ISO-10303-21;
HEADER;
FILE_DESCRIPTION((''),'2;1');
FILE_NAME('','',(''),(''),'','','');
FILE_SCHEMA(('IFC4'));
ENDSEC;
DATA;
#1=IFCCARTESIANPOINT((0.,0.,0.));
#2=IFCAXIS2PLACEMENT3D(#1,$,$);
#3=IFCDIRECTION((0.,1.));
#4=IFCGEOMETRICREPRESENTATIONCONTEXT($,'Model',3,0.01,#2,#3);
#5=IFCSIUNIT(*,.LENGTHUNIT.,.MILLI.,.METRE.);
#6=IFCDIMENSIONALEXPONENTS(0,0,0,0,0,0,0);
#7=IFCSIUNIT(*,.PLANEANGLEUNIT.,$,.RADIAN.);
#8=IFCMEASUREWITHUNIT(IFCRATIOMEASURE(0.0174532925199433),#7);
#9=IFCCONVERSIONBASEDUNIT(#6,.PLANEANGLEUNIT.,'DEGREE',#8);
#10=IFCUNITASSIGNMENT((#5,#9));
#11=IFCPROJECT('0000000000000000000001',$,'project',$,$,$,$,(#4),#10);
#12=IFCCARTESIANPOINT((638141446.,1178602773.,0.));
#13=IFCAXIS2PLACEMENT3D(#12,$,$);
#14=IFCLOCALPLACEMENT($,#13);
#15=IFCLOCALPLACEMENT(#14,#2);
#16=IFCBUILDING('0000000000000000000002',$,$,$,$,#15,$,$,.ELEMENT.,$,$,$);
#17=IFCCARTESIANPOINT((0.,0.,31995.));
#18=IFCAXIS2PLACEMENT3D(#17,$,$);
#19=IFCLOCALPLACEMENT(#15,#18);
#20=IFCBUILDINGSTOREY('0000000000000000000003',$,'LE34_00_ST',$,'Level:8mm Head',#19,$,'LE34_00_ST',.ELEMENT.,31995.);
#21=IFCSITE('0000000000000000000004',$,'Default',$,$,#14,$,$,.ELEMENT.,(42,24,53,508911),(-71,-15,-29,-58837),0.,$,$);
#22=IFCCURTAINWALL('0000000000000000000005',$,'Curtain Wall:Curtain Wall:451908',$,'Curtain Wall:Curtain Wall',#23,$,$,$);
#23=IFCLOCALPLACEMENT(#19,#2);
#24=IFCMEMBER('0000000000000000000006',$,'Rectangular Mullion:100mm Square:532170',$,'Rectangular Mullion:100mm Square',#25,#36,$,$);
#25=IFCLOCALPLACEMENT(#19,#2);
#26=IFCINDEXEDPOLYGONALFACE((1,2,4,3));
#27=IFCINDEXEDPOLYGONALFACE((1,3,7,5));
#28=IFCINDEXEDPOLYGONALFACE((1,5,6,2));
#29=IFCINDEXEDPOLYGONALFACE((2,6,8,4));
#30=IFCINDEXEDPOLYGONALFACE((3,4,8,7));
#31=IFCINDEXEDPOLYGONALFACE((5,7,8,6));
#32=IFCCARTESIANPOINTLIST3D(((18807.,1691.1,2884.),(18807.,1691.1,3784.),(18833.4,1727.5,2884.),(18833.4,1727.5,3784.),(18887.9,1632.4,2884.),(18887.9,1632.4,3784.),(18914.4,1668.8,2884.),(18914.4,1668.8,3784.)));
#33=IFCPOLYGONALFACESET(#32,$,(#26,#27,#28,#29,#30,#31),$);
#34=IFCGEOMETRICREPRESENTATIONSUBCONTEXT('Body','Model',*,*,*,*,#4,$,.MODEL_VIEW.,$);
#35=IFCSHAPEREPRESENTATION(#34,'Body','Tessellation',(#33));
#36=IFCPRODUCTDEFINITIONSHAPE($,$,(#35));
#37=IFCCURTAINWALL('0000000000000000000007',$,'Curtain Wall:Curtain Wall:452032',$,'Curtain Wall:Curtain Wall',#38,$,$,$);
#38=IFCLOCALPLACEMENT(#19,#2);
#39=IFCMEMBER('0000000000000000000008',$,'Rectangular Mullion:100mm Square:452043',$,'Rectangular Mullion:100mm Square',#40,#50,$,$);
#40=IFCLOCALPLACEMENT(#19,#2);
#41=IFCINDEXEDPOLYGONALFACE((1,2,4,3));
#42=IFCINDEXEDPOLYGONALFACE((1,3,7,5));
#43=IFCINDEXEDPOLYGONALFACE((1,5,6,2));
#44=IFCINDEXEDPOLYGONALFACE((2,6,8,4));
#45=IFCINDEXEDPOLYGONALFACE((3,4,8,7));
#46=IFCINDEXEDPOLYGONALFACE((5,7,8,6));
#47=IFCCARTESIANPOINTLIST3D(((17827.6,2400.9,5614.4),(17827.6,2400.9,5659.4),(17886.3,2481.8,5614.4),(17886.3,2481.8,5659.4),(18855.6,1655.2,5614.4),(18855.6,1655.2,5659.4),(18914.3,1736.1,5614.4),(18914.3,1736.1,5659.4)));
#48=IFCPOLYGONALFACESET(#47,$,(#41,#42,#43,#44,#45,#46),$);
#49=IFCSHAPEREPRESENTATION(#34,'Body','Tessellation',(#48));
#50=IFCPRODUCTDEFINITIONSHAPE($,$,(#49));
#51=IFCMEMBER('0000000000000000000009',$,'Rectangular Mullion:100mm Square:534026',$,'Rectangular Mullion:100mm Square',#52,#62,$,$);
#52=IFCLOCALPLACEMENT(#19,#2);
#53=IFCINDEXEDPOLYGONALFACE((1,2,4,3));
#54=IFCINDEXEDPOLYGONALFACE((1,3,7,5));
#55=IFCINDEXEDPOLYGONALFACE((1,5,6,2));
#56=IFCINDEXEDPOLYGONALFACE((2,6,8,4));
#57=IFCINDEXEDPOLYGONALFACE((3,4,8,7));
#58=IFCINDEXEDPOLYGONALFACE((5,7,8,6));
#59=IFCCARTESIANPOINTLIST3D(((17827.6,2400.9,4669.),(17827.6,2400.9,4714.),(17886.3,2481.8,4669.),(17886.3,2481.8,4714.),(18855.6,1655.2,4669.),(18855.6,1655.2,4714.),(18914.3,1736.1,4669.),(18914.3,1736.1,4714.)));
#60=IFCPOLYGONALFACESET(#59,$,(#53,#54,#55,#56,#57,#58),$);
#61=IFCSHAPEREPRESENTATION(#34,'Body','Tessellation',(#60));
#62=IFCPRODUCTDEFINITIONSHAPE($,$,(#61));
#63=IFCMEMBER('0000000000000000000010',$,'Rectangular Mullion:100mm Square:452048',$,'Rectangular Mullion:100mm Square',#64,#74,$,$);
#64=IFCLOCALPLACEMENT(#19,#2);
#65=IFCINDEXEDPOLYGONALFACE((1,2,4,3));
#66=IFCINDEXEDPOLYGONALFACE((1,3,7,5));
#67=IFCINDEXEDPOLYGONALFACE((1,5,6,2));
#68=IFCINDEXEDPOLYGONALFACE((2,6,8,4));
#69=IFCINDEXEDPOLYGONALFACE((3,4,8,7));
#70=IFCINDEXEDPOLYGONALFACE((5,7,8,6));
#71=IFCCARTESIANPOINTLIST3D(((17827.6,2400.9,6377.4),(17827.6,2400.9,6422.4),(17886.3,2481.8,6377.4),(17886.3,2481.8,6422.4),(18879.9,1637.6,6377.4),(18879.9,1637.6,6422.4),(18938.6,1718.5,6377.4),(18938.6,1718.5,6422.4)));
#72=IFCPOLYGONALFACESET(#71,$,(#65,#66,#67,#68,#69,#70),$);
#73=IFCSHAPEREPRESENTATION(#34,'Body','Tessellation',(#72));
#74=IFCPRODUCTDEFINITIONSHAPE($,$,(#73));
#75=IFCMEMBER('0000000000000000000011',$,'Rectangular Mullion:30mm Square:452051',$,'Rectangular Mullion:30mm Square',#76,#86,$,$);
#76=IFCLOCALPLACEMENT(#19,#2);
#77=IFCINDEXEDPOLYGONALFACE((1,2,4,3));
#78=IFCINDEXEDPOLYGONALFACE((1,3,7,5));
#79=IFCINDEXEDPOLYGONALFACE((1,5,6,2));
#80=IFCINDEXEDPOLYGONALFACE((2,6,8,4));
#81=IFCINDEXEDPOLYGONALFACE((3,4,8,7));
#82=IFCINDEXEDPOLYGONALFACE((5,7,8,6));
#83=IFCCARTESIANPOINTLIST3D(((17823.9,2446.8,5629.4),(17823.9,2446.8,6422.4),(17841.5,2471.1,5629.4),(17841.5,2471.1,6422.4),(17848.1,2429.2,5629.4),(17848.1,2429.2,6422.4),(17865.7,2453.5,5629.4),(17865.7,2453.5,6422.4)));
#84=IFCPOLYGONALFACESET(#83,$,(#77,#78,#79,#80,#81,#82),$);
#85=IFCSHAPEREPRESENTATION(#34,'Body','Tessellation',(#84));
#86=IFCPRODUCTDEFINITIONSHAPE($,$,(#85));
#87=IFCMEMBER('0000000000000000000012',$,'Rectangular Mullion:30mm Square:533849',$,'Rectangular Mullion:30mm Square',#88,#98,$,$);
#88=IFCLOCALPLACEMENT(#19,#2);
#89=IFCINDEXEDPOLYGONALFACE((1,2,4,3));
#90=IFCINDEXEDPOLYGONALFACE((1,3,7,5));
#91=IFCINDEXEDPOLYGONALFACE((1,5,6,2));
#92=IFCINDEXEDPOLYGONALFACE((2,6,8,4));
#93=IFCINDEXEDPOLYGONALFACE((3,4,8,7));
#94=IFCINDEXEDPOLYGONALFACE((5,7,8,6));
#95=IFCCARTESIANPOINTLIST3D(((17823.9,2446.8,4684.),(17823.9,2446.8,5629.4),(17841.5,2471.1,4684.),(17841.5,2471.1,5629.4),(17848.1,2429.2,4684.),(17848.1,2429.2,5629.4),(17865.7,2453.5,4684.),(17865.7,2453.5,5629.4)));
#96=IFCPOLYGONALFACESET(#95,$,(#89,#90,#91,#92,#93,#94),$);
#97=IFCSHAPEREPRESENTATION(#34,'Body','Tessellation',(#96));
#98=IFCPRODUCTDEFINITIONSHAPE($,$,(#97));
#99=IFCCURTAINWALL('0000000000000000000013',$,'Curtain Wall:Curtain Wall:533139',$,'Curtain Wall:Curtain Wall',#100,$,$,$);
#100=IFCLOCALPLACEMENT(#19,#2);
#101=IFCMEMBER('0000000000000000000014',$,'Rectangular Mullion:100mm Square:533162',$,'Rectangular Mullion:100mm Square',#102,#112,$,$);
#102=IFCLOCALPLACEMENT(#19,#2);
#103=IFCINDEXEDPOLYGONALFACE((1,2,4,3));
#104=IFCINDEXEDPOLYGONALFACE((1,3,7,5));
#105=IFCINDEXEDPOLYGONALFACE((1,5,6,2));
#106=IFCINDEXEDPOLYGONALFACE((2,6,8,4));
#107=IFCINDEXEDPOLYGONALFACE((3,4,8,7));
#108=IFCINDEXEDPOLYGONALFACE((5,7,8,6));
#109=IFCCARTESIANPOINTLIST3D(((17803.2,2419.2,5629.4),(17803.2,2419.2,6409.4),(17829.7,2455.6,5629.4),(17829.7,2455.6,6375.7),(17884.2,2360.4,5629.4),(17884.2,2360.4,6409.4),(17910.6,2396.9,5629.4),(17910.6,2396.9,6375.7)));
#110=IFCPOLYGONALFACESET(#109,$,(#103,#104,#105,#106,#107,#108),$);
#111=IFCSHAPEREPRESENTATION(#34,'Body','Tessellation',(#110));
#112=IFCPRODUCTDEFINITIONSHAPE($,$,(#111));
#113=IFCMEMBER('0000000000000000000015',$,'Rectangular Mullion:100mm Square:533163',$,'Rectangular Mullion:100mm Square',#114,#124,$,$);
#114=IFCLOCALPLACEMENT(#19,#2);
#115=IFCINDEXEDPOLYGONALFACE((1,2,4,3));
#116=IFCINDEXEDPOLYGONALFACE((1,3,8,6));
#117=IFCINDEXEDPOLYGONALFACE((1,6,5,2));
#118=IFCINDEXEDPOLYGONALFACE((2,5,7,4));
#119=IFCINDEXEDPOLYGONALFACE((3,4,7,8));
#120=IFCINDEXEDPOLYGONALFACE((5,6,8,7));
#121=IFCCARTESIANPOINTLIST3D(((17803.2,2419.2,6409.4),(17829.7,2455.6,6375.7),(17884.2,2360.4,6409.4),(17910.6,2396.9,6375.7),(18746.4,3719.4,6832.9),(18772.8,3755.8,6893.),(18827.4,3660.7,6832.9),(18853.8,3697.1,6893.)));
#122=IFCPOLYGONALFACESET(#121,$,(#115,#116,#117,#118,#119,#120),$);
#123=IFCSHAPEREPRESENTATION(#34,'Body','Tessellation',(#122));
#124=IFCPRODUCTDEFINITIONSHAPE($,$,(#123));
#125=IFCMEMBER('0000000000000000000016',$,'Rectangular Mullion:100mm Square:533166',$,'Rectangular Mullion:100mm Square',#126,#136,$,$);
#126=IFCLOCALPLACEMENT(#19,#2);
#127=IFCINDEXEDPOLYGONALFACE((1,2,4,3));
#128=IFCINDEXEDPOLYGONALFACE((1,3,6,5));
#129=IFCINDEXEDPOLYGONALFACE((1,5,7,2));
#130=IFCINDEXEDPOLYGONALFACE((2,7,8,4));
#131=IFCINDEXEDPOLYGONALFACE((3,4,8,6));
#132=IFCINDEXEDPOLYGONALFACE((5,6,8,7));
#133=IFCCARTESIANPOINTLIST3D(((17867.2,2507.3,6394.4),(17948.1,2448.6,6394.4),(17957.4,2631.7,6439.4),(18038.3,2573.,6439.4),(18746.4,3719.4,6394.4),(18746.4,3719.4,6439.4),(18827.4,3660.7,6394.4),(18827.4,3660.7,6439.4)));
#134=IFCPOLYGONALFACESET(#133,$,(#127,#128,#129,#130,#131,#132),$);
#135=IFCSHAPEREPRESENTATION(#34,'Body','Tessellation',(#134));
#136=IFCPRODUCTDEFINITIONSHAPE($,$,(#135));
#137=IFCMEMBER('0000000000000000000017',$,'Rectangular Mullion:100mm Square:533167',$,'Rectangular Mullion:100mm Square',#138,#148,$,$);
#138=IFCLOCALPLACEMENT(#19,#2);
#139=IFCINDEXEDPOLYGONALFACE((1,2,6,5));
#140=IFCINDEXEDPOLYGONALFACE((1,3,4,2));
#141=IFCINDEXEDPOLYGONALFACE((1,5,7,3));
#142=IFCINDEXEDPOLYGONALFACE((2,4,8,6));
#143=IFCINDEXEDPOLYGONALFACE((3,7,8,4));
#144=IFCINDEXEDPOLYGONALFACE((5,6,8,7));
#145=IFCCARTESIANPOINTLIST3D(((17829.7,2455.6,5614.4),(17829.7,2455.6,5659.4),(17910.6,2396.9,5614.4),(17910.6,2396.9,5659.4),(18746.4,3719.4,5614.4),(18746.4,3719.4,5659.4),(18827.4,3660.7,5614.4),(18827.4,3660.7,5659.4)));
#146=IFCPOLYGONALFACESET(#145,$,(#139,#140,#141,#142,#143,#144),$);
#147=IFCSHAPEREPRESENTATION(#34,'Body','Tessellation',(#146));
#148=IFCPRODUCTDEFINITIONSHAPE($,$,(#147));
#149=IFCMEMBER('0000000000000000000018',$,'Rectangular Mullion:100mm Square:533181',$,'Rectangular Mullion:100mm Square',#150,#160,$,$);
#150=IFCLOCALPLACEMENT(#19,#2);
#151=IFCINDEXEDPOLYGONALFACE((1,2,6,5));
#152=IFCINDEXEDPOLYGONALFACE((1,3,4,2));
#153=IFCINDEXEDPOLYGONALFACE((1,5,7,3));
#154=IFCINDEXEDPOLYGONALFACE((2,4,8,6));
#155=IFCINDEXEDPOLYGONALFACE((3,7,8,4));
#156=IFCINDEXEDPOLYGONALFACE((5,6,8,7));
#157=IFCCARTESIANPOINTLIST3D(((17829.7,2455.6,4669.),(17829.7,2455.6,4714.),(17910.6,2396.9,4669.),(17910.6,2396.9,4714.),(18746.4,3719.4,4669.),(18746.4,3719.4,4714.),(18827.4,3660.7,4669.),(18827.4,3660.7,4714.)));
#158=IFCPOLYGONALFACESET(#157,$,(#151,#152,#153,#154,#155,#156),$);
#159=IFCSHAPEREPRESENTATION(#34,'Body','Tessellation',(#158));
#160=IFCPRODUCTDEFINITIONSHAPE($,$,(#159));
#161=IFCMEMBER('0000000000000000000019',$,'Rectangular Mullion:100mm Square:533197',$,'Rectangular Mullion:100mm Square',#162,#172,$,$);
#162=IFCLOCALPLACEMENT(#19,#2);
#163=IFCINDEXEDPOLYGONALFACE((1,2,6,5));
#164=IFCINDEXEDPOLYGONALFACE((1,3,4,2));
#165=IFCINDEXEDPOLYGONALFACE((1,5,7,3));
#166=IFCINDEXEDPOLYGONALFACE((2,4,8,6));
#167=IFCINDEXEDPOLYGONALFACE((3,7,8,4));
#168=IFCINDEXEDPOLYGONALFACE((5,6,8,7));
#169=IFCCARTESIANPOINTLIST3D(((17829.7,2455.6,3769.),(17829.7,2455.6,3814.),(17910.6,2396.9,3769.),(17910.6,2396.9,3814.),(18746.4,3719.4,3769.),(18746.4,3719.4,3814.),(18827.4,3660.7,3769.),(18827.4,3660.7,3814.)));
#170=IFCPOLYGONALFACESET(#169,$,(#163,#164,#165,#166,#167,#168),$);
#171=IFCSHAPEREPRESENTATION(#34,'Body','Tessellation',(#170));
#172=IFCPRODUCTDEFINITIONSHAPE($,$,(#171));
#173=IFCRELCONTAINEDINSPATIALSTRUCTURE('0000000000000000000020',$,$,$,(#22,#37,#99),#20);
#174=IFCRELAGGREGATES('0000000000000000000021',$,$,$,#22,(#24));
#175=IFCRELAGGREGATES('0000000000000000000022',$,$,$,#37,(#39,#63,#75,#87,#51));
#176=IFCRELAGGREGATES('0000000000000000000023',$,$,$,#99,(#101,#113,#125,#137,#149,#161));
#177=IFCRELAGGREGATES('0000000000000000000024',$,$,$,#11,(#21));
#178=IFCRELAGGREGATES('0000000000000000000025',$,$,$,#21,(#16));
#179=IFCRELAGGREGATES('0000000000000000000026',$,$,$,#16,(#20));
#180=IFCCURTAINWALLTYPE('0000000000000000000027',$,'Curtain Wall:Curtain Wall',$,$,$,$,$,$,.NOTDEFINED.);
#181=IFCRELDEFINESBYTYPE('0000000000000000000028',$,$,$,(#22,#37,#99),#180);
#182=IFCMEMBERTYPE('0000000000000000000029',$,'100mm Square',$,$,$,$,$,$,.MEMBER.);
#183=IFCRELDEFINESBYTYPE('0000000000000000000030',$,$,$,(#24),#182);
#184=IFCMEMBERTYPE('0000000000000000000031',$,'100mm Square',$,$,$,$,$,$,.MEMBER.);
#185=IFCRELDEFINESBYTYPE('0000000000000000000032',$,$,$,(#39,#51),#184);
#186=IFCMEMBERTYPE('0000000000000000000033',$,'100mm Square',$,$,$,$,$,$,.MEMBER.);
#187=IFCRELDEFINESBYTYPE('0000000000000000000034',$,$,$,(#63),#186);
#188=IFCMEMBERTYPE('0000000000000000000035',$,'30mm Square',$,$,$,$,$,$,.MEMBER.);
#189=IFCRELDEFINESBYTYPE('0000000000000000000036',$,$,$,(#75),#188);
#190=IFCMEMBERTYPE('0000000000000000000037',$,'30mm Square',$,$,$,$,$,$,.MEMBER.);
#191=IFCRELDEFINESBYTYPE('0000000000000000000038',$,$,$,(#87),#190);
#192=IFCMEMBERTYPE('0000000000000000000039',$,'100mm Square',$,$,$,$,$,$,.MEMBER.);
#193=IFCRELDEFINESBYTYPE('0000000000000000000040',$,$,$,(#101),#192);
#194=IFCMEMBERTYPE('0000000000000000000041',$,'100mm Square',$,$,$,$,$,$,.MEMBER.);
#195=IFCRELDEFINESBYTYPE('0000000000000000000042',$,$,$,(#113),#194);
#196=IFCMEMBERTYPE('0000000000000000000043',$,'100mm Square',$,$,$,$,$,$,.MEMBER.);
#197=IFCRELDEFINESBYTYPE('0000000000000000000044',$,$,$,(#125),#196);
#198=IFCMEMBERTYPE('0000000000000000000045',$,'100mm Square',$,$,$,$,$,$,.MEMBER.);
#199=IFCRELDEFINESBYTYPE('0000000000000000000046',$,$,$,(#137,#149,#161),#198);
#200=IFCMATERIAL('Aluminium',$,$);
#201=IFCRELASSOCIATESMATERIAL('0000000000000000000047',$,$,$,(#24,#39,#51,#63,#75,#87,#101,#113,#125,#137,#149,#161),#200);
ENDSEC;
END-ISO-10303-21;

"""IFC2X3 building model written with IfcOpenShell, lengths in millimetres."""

from ifc_helpers import new_model, entity, si_unit, converted_unit, direction, frame, frame_2d, origin, origin_2d_with_axis, place, context, subcontext, project, spatial, rectangle, extrude, clip, halfspace, source, transform, mapped, material, type_object, type_shapes, element, aggregate, save


model = new_model("IFC2X3")

# Units and contexts
model_context = context("Model", 3, precision=0.01, world=origin(), true_north=direction((0.0, 1.0)))
body_context = subcontext(model_context, "Body", "Model", "MODEL_VIEW")
ifc_project = project(units=[si_unit("LENGTHUNIT", "METRE", prefix="MILLI"), converted_unit("PLANEANGLEUNIT", "DEGREE", entity("IfcRatioMeasure", 0.0174532925199433), si_unit("PLANEANGLEUNIT", "RADIAN"), dimensions=[0, 0, 0, 0, 0, 0, 0])], contexts=[model_context])

# Site, building, storey
site_placement = place(None, frame((638141446.0, 1178602773.0, 0.0)))
site = spatial("IfcSite", under=ifc_project, at=site_placement, Name="Default", CompositionType="ELEMENT", RefLatitude=(42, 24, 53, 508911), RefLongitude=(-71, -15, -29, -58837), RefElevation=0.0)
building_placement = place(site_placement, origin())
building = spatial("IfcBuilding", under=site, at=building_placement, CompositionType="ELEMENT")
storey_placement = place(building_placement, frame((0.0, 0.0, 31995.0)))
storey = spatial("IfcBuildingStorey", under=building, at=storey_placement, Name="LE34_00_ST", ObjectType="Level:8mm Head", LongName="LE34_00_ST", CompositionType="ELEMENT", Elevation=31995.0)

# Curtain wall, member
curtain_wall_type = type_object("IfcCurtainWallType", Name="Curtain Wall:Curtain Wall", PredefinedType="NOTDEFINED")
curtain_wall_1_placement = place(storey_placement, frame((0.0, 0.0, -31995.0)))
curtain_wall_1 = element("IfcCurtainWall", 1, at=curtain_wall_1_placement, inside=storey, type_object=curtain_wall_type, Name="Curtain Wall:Curtain Wall:451908", ObjectType="Curtain Wall:Curtain Wall")
ifc_material_1 = material(Name="Aluminium")
member_type_1 = type_object("IfcMemberType", Name="100mm Square", PredefinedType="MEMBER")
shared_shape_1 = source(origin(), body_context, "Body", "SweptSolid", [
    extrude(rectangle(XDim=100.0, YDim=45.0, at=origin_2d_with_axis()), frame((-22.5, 0.0, -900.0), z_axis=(0.0, 0.0, 1.0), x_axis=(0.0, -1.0, 0.0)), (0.0, 0.0, 1.0), 900.0),
])
type_shapes(member_type_1, [shared_shape_1])
member_1_placement = place(storey_placement, frame((18847.5, 1661.7, 3784.0), z_axis=(0.0, 0.0, 1.0), x_axis=(-0.587164, -0.809468, 0.0)))
member_1 = element("IfcMember", 2, at=member_1_placement, type_object=member_type_1, material=ifc_material_1, Name="Rectangular Mullion:100mm Square:532170", ObjectType="Rectangular Mullion:100mm Square", context=body_context, shape_type="MappedRepresentation", body=[
    mapped(shared_shape_1, transform((0.0, 0.0, 0.0), scale=1.0)),
])
aggregate(curtain_wall_1, [member_1])

# Curtain walls, members
curtain_wall_2_placement = place(storey_placement, frame((0.0, 0.0, -31995.0)))
curtain_wall_2 = element("IfcCurtainWall", 3, at=curtain_wall_2_placement, inside=storey, type_object=curtain_wall_type, Name="Curtain Wall:Curtain Wall:452032", ObjectType="Curtain Wall:Curtain Wall")
member_type_2 = type_object("IfcMemberType", Name="100mm Square", PredefinedType="MEMBER")
shared_shape_2 = source(origin(), body_context, "Body", "SweptSolid", [
    extrude(rectangle(XDim=100.0, YDim=45.0, at=origin_2d_with_axis()), frame((7.5, 0.0, -1270.0), z_axis=(0.0, 0.0, 1.0), x_axis=(0.0, -1.0, 0.0)), (0.0, 0.0, 1.0), 1270.0),
])
type_shapes(member_type_2, [shared_shape_2])
member_2_placement = place(storey_placement, frame((17856.9, 2441.4, 5629.4), z_axis=(-0.809468, 0.587164, 0.0), x_axis=(0.0, 0.0, 1.0)))
member_2 = element("IfcMember", 4, at=member_2_placement, type_object=member_type_2, material=ifc_material_1, Name="Rectangular Mullion:100mm Square:452043", ObjectType="Rectangular Mullion:100mm Square", context=body_context, shape_type="MappedRepresentation", body=[
    mapped(shared_shape_2, transform((0.0, 0.0, 0.0), scale=1.0)),
])
member_3_placement = place(storey_placement, frame((17856.9, 2441.4, 4684.0), z_axis=(-0.809468, 0.587164, 0.0), x_axis=(0.0, 0.0, 1.0)))
member_3 = element("IfcMember", 5, at=member_3_placement, type_object=member_type_2, material=ifc_material_1, Name="Rectangular Mullion:100mm Square:534026", ObjectType="Rectangular Mullion:100mm Square", context=body_context, shape_type="MappedRepresentation", body=[
    mapped(shared_shape_2, transform((0.0, 0.0, 0.0), scale=1.0)),
])
member_type_3 = type_object("IfcMemberType", Name="100mm Square", PredefinedType="MEMBER")
shared_shape_3 = source(origin(), body_context, "Body", "SweptSolid", [
    extrude(rectangle(XDim=100.0, YDim=45.0, at=origin_2d_with_axis()), frame((-22.5, 0.0, -1300.0), z_axis=(0.0, 0.0, 1.0), x_axis=(0.0, -1.0, 0.0)), (0.0, 0.0, 1.0), 1300.0),
])
type_shapes(member_type_3, [shared_shape_3])
member_4_placement = place(storey_placement, frame((17856.9, 2441.4, 6422.4), z_axis=(-0.809468, 0.587164, 0.0), x_axis=(0.0, 0.0, 1.0)))
member_4 = element("IfcMember", 6, at=member_4_placement, type_object=member_type_3, material=ifc_material_1, Name="Rectangular Mullion:100mm Square:452048", ObjectType="Rectangular Mullion:100mm Square", context=body_context, shape_type="MappedRepresentation", body=[
    mapped(shared_shape_3, transform((0.0, 0.0, 0.0), scale=1.0)),
])
member_type_4 = type_object("IfcMemberType", Name="30mm Square", PredefinedType="MEMBER")
shared_shape_4 = source(origin(), body_context, "Body", "SweptSolid", [
    extrude(rectangle(XDim=30.0, YDim=30.0, at=origin_2d_with_axis()), frame((-15.0, 0.0, -793.0), z_axis=(0.0, 0.0, 1.0), x_axis=(0.0, -1.0, 0.0)), (0.0, 0.0, 1.0), 793.0),
])
type_shapes(member_type_4, [shared_shape_4])
member_5_placement = place(storey_placement, frame((17832.7, 2459.0, 5629.4), z_axis=(0.0, 0.0, -1.0), x_axis=(-0.809468, 0.587164, 0.0)))
member_5 = element("IfcMember", 7, at=member_5_placement, type_object=member_type_4, material=ifc_material_1, Name="Rectangular Mullion:30mm Square:452051", ObjectType="Rectangular Mullion:30mm Square", context=body_context, shape_type="MappedRepresentation", body=[
    mapped(shared_shape_4, transform((0.0, 0.0, 0.0), scale=1.0)),
])
member_type_5 = type_object("IfcMemberType", Name="30mm Square", PredefinedType="MEMBER")
shared_shape_5 = source(origin(), body_context, "Body", "SweptSolid", [
    extrude(rectangle(XDim=30.0, YDim=30.0, at=origin_2d_with_axis()), frame((-15.0, 0.0, -945.4), z_axis=(0.0, 0.0, 1.0), x_axis=(0.0, -1.0, 0.0)), (0.0, 0.0, 1.0), 945.4),
])
type_shapes(member_type_5, [shared_shape_5])
member_6_placement = place(storey_placement, frame((17832.7, 2459.0, 4684.0), z_axis=(0.0, 0.0, -1.0), x_axis=(-0.809468, 0.587164, 0.0)))
member_6 = element("IfcMember", 8, at=member_6_placement, type_object=member_type_5, material=ifc_material_1, Name="Rectangular Mullion:30mm Square:533849", ObjectType="Rectangular Mullion:30mm Square", context=body_context, shape_type="MappedRepresentation", body=[
    mapped(shared_shape_5, transform((0.0, 0.0, 0.0), scale=1.0)),
])
curtain_wall_3_placement = place(storey_placement, frame((0.0, 0.0, -31995.0)))
curtain_wall_3 = element("IfcCurtainWall", 9, at=curtain_wall_3_placement, inside=storey, type_object=curtain_wall_type, Name="Curtain Wall:Curtain Wall:533139", ObjectType="Curtain Wall:Curtain Wall")
member_type_6 = type_object("IfcMemberType", Name="100mm Square", PredefinedType="MEMBER")
shared_shape_6 = source(origin(), body_context, "Body", "Clipping", [
    clip(extrude(rectangle(XDim=100.0, YDim=45.0, at=origin_2d_with_axis()), frame((-22.5, 0.0, -780.0), z_axis=(0.0, 0.0, 1.0), x_axis=(0.0, -1.0, 0.0)), (0.0, 0.0, 1.0), 780.0), halfspace(frame((0.0, -304.8, 0.0), z_axis=(-0.599555, 0.0, 0.800333), x_axis=(-0.800333, 0.0, -0.599555)), False)),
])
type_shapes(member_type_6, [shared_shape_6])
member_7_placement = place(storey_placement, frame((17843.7, 2389.8, 6409.4), z_axis=(0.0, 0.0, 1.0), x_axis=(-0.587164, -0.809468, 0.0)))
member_7 = element("IfcMember", 10, at=member_7_placement, type_object=member_type_6, material=ifc_material_1, Name="Rectangular Mullion:100mm Square:533162", ObjectType="Rectangular Mullion:100mm Square", context=body_context, shape_type="MappedRepresentation", body=[
    mapped(shared_shape_6, transform((0.0, 0.0, 0.0), scale=1.0)),
])
member_type_7 = type_object("IfcMemberType", Name="100mm Square", PredefinedType="MEMBER")
shared_shape_7 = source(origin(), body_context, "Body", "Clipping", [
    clip(clip(extrude(rectangle(XDim=100.0, YDim=45.0, at=frame_2d((0.0, 0.0), x_axis=(1.0, 0.0))), frame((-22.5, 0.0, -1720.6), z_axis=(0.0, 0.0, 1.0), x_axis=(0.0, -1.0, 0.0)), (0.0, 0.0, 1.0), 1720.6), halfspace(frame((0.0, -304.8, -1720.6), z_axis=(-0.599555, 0.0, -0.800333), x_axis=(-0.800333, 0.0, 0.599555)), False)), halfspace(frame((0.0, -304.8, 0.0), z_axis=(-0.800333, 0.0, 0.599555), x_axis=(-0.599555, 0.0, -0.800333)), False)),
])
type_shapes(member_type_7, [shared_shape_7])
member_8_placement = place(storey_placement, frame((18813.3, 3726.5, 6893.0), z_axis=(0.563495, 0.776837, 0.281067), x_axis=(-0.165032, -0.227515, 0.959688)))
member_8 = element("IfcMember", 11, at=member_8_placement, type_object=member_type_7, material=ifc_material_1, Name="Rectangular Mullion:100mm Square:533163", ObjectType="Rectangular Mullion:100mm Square", context=body_context, shape_type="MappedRepresentation", body=[
    mapped(shared_shape_7, transform((0.0, 0.0, 0.0), scale=1.0)),
])
member_type_8 = type_object("IfcMemberType", Name="100mm Square", PredefinedType="MEMBER")
shared_shape_8 = source(origin(), body_context, "Body", "Clipping", [
    clip(extrude(rectangle(XDim=100.0, YDim=45.0, at=origin_2d_with_axis()), frame((7.5, 0.0, -1497.4), z_axis=(0.0, 0.0, 1.0), x_axis=(0.0, -1.0, 0.0)), (0.0, 0.0, 1.0), 1497.4), halfspace(frame((440.4, 50.0, 57.6), z_axis=(0.959688, 0.0, -0.281067), x_axis=(-0.281067, 0.0, -0.959688)), False)),
])
type_shapes(member_type_8, [shared_shape_8])
member_9_placement = place(storey_placement, frame((18786.9, 3690.0, 6409.4), z_axis=(0.587164, 0.809468, 0.0), x_axis=(0.0, 0.0, 1.0)))
member_9 = element("IfcMember", 12, at=member_9_placement, type_object=member_type_8, material=ifc_material_1, Name="Rectangular Mullion:100mm Square:533166", ObjectType="Rectangular Mullion:100mm Square", context=body_context, shape_type="MappedRepresentation", body=[
    mapped(shared_shape_8, transform((0.0, 0.0, 0.0), scale=1.0)),
])
member_type_9 = type_object("IfcMemberType", Name="100mm Square", PredefinedType="MEMBER")
shared_shape_9 = source(origin(), body_context, "Body", "SweptSolid", [
    extrude(rectangle(XDim=100.0, YDim=45.0, at=origin_2d_with_axis()), frame((7.5, 0.0, -1561.3), z_axis=(0.0, 0.0, 1.0), x_axis=(0.0, -1.0, 0.0)), (0.0, 0.0, 1.0), 1561.3),
])
type_shapes(member_type_9, [shared_shape_9])
member_10_placement = place(storey_placement, frame((18786.9, 3690.0, 5629.4), z_axis=(0.587164, 0.809468, 0.0), x_axis=(0.0, 0.0, 1.0)))
member_10 = element("IfcMember", 13, at=member_10_placement, type_object=member_type_9, material=ifc_material_1, Name="Rectangular Mullion:100mm Square:533167", ObjectType="Rectangular Mullion:100mm Square", context=body_context, shape_type="MappedRepresentation", body=[
    mapped(shared_shape_9, transform((0.0, 0.0, 0.0), scale=1.0)),
])
member_11_placement = place(storey_placement, frame((18786.9, 3690.0, 4684.0), z_axis=(0.587164, 0.809468, 0.0), x_axis=(0.0, 0.0, 1.0)))
member_11 = element("IfcMember", 14, at=member_11_placement, type_object=member_type_9, material=ifc_material_1, Name="Rectangular Mullion:100mm Square:533181", ObjectType="Rectangular Mullion:100mm Square", context=body_context, shape_type="MappedRepresentation", body=[
    mapped(shared_shape_9, transform((0.0, 0.0, 0.0), scale=1.0)),
])
member_12_placement = place(storey_placement, frame((18786.9, 3690.0, 3784.0), z_axis=(0.587164, 0.809468, 0.0), x_axis=(0.0, 0.0, 1.0)))
member_12 = element("IfcMember", 15, at=member_12_placement, type_object=member_type_9, material=ifc_material_1, Name="Rectangular Mullion:100mm Square:533197", ObjectType="Rectangular Mullion:100mm Square", context=body_context, shape_type="MappedRepresentation", body=[
    mapped(shared_shape_9, transform((0.0, 0.0, 0.0), scale=1.0)),
])

aggregate(curtain_wall_2, [member_2, member_4, member_5, member_6, member_3])
aggregate(curtain_wall_3, [member_7, member_8, member_9, member_10, member_11, member_12])

save(model, "model.ifc")
